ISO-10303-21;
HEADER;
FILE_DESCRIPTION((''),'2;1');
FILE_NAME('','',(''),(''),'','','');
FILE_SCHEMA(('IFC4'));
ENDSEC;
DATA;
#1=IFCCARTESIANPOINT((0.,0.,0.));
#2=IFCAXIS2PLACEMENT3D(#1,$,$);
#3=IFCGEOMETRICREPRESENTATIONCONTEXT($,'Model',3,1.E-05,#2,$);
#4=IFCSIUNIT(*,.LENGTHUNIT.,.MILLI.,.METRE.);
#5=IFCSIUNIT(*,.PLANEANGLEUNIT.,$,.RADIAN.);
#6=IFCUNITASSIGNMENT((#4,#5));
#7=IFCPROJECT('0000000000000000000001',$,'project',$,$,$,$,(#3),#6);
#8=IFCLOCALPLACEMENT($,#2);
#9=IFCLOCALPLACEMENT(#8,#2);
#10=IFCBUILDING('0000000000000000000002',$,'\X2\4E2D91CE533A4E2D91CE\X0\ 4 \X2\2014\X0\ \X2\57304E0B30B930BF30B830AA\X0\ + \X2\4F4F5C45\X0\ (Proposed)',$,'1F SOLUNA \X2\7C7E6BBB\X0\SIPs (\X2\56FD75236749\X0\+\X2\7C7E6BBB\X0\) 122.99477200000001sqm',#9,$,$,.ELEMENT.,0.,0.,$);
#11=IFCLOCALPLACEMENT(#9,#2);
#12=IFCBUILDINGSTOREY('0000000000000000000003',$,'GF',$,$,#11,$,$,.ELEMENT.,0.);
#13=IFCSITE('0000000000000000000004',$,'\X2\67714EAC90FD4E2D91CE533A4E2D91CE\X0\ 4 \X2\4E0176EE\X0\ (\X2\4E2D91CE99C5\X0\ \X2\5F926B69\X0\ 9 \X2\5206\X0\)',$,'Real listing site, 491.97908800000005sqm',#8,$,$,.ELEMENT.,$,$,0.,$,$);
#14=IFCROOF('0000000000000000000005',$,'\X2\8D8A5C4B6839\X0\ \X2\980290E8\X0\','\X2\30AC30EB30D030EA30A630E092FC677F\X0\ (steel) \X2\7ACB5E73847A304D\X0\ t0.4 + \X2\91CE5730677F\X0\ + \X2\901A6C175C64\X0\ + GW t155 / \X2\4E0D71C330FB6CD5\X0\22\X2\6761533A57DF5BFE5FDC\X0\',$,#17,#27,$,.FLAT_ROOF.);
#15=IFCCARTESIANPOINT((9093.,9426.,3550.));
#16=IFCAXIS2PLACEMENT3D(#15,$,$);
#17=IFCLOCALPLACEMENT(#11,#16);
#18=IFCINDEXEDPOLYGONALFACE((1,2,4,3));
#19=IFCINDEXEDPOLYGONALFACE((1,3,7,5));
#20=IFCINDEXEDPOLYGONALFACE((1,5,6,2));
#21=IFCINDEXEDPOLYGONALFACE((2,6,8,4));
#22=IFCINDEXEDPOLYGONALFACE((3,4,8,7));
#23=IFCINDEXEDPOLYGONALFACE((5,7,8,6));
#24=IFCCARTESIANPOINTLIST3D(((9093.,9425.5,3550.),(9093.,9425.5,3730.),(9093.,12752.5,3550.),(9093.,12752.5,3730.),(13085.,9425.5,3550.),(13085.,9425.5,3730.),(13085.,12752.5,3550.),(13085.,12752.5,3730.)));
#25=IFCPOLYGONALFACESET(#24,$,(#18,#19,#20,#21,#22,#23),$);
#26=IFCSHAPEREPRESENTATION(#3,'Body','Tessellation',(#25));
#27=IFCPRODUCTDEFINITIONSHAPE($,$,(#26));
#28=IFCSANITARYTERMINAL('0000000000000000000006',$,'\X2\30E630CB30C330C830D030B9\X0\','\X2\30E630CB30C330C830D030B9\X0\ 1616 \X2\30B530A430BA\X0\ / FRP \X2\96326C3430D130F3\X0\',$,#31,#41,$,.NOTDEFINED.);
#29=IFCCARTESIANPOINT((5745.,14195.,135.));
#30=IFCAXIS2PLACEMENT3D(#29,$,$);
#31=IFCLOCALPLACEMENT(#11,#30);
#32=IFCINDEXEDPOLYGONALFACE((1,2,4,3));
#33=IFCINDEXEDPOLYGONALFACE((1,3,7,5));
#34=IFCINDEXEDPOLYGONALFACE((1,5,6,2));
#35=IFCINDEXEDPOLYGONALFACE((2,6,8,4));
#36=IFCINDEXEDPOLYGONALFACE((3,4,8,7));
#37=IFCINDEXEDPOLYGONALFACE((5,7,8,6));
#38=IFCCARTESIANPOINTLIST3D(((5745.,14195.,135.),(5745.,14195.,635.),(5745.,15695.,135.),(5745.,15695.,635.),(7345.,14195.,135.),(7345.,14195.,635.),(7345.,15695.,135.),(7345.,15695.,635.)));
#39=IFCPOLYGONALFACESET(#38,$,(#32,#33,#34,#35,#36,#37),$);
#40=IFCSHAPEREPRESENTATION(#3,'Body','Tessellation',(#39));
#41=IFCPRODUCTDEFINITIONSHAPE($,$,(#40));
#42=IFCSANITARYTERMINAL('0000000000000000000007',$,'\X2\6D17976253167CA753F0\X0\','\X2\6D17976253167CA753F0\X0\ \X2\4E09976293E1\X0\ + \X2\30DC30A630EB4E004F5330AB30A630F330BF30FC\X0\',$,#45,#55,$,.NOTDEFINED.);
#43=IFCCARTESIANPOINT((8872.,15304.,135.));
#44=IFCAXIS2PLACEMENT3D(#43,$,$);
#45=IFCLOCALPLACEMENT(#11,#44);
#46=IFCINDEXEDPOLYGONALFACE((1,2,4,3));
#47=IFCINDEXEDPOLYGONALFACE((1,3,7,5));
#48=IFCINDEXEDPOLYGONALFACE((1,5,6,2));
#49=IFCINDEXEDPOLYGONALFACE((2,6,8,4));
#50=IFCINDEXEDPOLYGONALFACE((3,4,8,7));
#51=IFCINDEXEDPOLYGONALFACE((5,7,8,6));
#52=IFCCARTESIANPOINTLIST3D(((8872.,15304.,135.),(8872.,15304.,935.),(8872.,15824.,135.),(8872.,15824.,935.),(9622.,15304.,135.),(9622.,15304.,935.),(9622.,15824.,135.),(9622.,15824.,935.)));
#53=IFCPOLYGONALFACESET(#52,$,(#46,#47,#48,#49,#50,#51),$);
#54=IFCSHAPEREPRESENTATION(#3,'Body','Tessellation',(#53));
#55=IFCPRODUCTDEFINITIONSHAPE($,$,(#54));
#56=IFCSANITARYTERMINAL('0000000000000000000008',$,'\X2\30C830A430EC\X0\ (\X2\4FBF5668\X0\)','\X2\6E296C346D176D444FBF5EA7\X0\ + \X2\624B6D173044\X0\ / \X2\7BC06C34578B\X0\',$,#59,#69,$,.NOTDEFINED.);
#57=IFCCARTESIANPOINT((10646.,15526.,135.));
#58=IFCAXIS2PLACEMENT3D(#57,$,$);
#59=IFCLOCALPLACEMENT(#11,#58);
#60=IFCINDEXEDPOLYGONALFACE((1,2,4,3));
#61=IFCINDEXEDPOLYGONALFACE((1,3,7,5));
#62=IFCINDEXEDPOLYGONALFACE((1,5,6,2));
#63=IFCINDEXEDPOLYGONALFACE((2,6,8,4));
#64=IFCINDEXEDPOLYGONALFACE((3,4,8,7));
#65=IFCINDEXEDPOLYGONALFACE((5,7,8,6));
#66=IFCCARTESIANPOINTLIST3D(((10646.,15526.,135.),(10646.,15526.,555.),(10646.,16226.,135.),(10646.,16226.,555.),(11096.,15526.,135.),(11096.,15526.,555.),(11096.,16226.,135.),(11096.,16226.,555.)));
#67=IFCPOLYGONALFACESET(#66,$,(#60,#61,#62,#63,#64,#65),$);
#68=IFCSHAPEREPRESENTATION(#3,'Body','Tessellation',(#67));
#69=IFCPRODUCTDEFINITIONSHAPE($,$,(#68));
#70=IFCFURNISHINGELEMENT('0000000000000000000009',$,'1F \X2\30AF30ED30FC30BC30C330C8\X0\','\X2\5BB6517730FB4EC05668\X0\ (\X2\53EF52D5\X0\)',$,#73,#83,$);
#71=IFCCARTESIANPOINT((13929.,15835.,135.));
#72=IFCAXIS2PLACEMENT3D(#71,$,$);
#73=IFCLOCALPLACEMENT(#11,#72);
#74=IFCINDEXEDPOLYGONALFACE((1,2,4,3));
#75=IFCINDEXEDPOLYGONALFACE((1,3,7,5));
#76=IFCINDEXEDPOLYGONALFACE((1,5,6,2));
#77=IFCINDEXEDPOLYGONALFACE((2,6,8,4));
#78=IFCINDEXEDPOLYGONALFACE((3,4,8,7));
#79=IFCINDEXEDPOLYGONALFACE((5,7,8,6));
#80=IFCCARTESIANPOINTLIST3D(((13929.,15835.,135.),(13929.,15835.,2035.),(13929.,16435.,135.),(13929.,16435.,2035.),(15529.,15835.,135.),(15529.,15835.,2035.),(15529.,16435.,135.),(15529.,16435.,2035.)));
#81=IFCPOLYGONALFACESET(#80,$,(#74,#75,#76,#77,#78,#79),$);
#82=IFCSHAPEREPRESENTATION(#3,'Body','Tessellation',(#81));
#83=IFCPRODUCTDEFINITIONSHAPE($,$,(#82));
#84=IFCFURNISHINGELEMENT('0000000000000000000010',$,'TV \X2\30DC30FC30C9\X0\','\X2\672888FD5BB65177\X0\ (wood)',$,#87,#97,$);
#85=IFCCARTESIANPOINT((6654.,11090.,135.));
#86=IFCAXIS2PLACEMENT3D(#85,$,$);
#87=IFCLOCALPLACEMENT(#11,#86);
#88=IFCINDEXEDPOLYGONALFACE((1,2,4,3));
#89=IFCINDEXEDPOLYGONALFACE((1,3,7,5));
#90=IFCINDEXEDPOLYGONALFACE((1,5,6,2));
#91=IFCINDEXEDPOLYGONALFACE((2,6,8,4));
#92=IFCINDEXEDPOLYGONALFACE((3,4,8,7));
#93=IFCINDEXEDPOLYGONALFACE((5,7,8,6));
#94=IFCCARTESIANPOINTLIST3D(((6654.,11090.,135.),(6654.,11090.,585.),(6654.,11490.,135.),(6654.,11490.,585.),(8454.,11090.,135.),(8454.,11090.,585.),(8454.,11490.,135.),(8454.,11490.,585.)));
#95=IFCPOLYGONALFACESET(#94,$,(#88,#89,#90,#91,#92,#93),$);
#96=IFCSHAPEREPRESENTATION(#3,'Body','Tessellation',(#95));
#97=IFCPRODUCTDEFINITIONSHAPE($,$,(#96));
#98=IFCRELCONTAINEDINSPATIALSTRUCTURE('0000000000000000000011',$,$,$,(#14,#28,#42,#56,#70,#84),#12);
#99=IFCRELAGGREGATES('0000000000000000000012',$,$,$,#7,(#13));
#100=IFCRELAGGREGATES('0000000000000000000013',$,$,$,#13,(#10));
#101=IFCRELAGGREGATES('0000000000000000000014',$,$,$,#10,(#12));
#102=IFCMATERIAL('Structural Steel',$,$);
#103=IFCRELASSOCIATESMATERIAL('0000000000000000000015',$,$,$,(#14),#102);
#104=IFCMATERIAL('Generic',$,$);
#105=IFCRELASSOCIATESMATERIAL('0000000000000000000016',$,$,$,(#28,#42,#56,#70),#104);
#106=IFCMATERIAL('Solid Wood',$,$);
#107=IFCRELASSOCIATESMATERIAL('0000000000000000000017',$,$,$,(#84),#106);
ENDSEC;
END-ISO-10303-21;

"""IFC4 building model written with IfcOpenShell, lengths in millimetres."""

from ifc_helpers import new_model, si_unit, frame, frame_2d, origin, place, context, project, spatial, rectangle, extrude, material, element, save


model = new_model("IFC4")

# Units and contexts
model_context = context("Model", 3, precision=1e-05, world=origin())
ifc_project = project(units=[si_unit("LENGTHUNIT", "METRE", prefix="MILLI"), si_unit("PLANEANGLEUNIT", "RADIAN")], contexts=[model_context])

# Site, building, storey
site_placement = place(None, origin())
site = spatial("IfcSite", under=ifc_project, at=site_placement, Name="東京都中野区中野 4 丁目 (中野駅 徒歩 9 分)", ObjectType="Real listing site, 491.97908800000005sqm", CompositionType="ELEMENT", RefElevation=0.0)
building_placement = place(site_placement, origin())
building = spatial("IfcBuilding", under=site, at=building_placement, Name="中野区中野 4 — 地下スタジオ + 住居 (Proposed)", ObjectType="1F SOLUNA 籾殻SIPs (国産杉+籾殻) 122.99477200000001sqm", CompositionType="ELEMENT", ElevationOfRefHeight=0.0, ElevationOfTerrain=0.0)
storey_placement = place(building_placement, origin())
storey = spatial("IfcBuildingStorey", under=building, at=storey_placement, Name="GF", CompositionType="ELEMENT", Elevation=0.0)

# Shared definitions
ifc_material_1 = material(Name="Solid Wood")

# Roof
ifc_material_2 = material(Name="Structural Steel")
roof_placement = place(storey_placement, frame((9093.0, 9426.0, 3550.0)))
element("IfcRoof", 1, at=roof_placement, inside=storey, material=ifc_material_2, Name="越屋根 頂部", Description="ガルバリウム鋼板 (steel) 立平葺き t0.4 + 野地板 + 通気層 + GW t155 / 不燃・法22条区域対応", PredefinedType="FLAT_ROOF", context=model_context, shape_type="SweptSolid", body=[
    extrude(rectangle(XDim=3992.0, YDim=3327.0, at=frame_2d((1996.0, 1663.0))), frame((9093.0, 9426.0, 3550.0)), (0.0, 0.0, 1.0), 180.0),
])

# Sanitary terminals
ifc_material_3 = material(Name="Generic")
sanitary_terminal_1_placement = place(storey_placement, frame((5745.0, 14195.0, 135.0)))
element("IfcSanitaryTerminal", 2, at=sanitary_terminal_1_placement, inside=storey, material=ifc_material_3, Name="ユニットバス", Description="ユニットバス 1616 サイズ / FRP 防水パン", PredefinedType="NOTDEFINED", context=model_context, shape_type="SweptSolid", body=[
    extrude(rectangle(XDim=1600.0, YDim=1500.0, at=frame_2d((800.0, 750.0))), frame((5745.0, 14195.0, 135.0)), (0.0, 0.0, 1.0), 500.0),
])
sanitary_terminal_2_placement = place(storey_placement, frame((8872.0, 15304.0, 135.0)))
element("IfcSanitaryTerminal", 3, at=sanitary_terminal_2_placement, inside=storey, material=ifc_material_3, Name="洗面化粧台", Description="洗面化粧台 三面鏡 + ボウル一体カウンター", PredefinedType="NOTDEFINED", context=model_context, shape_type="SweptSolid", body=[
    extrude(rectangle(XDim=750.0, YDim=520.0, at=frame_2d((375.0, 260.0))), frame((8872.0, 15304.0, 135.0)), (0.0, 0.0, 1.0), 800.0),
])
sanitary_terminal_3_placement = place(storey_placement, frame((10646.0, 15526.0, 135.0)))
element("IfcSanitaryTerminal", 4, at=sanitary_terminal_3_placement, inside=storey, material=ifc_material_3, Name="トイレ (便器)", Description="温水洗浄便座 + 手洗い / 節水型", PredefinedType="NOTDEFINED", context=model_context, shape_type="SweptSolid", body=[
    extrude(rectangle(XDim=450.0, YDim=700.0, at=frame_2d((225.0, 350.0))), frame((10646.0, 15526.0, 135.0)), (0.0, 0.0, 1.0), 420.0),
])

# Furnishing elements
furnishing_1_placement = place(storey_placement, frame((13929.0, 15835.0, 135.0)))
element("IfcFurnishingElement", 5, at=furnishing_1_placement, inside=storey, material=ifc_material_3, Name="1F クローゼット", Description="家具・什器 (可動)", context=model_context, shape_type="SweptSolid", body=[
    extrude(rectangle(XDim=1600.0, YDim=600.0, at=frame_2d((800.0, 300.0))), frame((13929.0, 15835.0, 135.0)), (0.0, 0.0, 1.0), 1900.0),
])
furnishing_2_placement = place(storey_placement, frame((6654.0, 11090.0, 135.0)))
element("IfcFurnishingElement", 6, at=furnishing_2_placement, inside=storey, material=ifc_material_1, Name="TV ボード", Description="木製家具 (wood)", context=model_context, shape_type="SweptSolid", body=[
    extrude(rectangle(XDim=1800.0, YDim=400.0, at=frame_2d((900.0, 200.0))), frame((6654.0, 11090.0, 135.0)), (0.0, 0.0, 1.0), 450.0),
])

save(model, "model.ifc")
